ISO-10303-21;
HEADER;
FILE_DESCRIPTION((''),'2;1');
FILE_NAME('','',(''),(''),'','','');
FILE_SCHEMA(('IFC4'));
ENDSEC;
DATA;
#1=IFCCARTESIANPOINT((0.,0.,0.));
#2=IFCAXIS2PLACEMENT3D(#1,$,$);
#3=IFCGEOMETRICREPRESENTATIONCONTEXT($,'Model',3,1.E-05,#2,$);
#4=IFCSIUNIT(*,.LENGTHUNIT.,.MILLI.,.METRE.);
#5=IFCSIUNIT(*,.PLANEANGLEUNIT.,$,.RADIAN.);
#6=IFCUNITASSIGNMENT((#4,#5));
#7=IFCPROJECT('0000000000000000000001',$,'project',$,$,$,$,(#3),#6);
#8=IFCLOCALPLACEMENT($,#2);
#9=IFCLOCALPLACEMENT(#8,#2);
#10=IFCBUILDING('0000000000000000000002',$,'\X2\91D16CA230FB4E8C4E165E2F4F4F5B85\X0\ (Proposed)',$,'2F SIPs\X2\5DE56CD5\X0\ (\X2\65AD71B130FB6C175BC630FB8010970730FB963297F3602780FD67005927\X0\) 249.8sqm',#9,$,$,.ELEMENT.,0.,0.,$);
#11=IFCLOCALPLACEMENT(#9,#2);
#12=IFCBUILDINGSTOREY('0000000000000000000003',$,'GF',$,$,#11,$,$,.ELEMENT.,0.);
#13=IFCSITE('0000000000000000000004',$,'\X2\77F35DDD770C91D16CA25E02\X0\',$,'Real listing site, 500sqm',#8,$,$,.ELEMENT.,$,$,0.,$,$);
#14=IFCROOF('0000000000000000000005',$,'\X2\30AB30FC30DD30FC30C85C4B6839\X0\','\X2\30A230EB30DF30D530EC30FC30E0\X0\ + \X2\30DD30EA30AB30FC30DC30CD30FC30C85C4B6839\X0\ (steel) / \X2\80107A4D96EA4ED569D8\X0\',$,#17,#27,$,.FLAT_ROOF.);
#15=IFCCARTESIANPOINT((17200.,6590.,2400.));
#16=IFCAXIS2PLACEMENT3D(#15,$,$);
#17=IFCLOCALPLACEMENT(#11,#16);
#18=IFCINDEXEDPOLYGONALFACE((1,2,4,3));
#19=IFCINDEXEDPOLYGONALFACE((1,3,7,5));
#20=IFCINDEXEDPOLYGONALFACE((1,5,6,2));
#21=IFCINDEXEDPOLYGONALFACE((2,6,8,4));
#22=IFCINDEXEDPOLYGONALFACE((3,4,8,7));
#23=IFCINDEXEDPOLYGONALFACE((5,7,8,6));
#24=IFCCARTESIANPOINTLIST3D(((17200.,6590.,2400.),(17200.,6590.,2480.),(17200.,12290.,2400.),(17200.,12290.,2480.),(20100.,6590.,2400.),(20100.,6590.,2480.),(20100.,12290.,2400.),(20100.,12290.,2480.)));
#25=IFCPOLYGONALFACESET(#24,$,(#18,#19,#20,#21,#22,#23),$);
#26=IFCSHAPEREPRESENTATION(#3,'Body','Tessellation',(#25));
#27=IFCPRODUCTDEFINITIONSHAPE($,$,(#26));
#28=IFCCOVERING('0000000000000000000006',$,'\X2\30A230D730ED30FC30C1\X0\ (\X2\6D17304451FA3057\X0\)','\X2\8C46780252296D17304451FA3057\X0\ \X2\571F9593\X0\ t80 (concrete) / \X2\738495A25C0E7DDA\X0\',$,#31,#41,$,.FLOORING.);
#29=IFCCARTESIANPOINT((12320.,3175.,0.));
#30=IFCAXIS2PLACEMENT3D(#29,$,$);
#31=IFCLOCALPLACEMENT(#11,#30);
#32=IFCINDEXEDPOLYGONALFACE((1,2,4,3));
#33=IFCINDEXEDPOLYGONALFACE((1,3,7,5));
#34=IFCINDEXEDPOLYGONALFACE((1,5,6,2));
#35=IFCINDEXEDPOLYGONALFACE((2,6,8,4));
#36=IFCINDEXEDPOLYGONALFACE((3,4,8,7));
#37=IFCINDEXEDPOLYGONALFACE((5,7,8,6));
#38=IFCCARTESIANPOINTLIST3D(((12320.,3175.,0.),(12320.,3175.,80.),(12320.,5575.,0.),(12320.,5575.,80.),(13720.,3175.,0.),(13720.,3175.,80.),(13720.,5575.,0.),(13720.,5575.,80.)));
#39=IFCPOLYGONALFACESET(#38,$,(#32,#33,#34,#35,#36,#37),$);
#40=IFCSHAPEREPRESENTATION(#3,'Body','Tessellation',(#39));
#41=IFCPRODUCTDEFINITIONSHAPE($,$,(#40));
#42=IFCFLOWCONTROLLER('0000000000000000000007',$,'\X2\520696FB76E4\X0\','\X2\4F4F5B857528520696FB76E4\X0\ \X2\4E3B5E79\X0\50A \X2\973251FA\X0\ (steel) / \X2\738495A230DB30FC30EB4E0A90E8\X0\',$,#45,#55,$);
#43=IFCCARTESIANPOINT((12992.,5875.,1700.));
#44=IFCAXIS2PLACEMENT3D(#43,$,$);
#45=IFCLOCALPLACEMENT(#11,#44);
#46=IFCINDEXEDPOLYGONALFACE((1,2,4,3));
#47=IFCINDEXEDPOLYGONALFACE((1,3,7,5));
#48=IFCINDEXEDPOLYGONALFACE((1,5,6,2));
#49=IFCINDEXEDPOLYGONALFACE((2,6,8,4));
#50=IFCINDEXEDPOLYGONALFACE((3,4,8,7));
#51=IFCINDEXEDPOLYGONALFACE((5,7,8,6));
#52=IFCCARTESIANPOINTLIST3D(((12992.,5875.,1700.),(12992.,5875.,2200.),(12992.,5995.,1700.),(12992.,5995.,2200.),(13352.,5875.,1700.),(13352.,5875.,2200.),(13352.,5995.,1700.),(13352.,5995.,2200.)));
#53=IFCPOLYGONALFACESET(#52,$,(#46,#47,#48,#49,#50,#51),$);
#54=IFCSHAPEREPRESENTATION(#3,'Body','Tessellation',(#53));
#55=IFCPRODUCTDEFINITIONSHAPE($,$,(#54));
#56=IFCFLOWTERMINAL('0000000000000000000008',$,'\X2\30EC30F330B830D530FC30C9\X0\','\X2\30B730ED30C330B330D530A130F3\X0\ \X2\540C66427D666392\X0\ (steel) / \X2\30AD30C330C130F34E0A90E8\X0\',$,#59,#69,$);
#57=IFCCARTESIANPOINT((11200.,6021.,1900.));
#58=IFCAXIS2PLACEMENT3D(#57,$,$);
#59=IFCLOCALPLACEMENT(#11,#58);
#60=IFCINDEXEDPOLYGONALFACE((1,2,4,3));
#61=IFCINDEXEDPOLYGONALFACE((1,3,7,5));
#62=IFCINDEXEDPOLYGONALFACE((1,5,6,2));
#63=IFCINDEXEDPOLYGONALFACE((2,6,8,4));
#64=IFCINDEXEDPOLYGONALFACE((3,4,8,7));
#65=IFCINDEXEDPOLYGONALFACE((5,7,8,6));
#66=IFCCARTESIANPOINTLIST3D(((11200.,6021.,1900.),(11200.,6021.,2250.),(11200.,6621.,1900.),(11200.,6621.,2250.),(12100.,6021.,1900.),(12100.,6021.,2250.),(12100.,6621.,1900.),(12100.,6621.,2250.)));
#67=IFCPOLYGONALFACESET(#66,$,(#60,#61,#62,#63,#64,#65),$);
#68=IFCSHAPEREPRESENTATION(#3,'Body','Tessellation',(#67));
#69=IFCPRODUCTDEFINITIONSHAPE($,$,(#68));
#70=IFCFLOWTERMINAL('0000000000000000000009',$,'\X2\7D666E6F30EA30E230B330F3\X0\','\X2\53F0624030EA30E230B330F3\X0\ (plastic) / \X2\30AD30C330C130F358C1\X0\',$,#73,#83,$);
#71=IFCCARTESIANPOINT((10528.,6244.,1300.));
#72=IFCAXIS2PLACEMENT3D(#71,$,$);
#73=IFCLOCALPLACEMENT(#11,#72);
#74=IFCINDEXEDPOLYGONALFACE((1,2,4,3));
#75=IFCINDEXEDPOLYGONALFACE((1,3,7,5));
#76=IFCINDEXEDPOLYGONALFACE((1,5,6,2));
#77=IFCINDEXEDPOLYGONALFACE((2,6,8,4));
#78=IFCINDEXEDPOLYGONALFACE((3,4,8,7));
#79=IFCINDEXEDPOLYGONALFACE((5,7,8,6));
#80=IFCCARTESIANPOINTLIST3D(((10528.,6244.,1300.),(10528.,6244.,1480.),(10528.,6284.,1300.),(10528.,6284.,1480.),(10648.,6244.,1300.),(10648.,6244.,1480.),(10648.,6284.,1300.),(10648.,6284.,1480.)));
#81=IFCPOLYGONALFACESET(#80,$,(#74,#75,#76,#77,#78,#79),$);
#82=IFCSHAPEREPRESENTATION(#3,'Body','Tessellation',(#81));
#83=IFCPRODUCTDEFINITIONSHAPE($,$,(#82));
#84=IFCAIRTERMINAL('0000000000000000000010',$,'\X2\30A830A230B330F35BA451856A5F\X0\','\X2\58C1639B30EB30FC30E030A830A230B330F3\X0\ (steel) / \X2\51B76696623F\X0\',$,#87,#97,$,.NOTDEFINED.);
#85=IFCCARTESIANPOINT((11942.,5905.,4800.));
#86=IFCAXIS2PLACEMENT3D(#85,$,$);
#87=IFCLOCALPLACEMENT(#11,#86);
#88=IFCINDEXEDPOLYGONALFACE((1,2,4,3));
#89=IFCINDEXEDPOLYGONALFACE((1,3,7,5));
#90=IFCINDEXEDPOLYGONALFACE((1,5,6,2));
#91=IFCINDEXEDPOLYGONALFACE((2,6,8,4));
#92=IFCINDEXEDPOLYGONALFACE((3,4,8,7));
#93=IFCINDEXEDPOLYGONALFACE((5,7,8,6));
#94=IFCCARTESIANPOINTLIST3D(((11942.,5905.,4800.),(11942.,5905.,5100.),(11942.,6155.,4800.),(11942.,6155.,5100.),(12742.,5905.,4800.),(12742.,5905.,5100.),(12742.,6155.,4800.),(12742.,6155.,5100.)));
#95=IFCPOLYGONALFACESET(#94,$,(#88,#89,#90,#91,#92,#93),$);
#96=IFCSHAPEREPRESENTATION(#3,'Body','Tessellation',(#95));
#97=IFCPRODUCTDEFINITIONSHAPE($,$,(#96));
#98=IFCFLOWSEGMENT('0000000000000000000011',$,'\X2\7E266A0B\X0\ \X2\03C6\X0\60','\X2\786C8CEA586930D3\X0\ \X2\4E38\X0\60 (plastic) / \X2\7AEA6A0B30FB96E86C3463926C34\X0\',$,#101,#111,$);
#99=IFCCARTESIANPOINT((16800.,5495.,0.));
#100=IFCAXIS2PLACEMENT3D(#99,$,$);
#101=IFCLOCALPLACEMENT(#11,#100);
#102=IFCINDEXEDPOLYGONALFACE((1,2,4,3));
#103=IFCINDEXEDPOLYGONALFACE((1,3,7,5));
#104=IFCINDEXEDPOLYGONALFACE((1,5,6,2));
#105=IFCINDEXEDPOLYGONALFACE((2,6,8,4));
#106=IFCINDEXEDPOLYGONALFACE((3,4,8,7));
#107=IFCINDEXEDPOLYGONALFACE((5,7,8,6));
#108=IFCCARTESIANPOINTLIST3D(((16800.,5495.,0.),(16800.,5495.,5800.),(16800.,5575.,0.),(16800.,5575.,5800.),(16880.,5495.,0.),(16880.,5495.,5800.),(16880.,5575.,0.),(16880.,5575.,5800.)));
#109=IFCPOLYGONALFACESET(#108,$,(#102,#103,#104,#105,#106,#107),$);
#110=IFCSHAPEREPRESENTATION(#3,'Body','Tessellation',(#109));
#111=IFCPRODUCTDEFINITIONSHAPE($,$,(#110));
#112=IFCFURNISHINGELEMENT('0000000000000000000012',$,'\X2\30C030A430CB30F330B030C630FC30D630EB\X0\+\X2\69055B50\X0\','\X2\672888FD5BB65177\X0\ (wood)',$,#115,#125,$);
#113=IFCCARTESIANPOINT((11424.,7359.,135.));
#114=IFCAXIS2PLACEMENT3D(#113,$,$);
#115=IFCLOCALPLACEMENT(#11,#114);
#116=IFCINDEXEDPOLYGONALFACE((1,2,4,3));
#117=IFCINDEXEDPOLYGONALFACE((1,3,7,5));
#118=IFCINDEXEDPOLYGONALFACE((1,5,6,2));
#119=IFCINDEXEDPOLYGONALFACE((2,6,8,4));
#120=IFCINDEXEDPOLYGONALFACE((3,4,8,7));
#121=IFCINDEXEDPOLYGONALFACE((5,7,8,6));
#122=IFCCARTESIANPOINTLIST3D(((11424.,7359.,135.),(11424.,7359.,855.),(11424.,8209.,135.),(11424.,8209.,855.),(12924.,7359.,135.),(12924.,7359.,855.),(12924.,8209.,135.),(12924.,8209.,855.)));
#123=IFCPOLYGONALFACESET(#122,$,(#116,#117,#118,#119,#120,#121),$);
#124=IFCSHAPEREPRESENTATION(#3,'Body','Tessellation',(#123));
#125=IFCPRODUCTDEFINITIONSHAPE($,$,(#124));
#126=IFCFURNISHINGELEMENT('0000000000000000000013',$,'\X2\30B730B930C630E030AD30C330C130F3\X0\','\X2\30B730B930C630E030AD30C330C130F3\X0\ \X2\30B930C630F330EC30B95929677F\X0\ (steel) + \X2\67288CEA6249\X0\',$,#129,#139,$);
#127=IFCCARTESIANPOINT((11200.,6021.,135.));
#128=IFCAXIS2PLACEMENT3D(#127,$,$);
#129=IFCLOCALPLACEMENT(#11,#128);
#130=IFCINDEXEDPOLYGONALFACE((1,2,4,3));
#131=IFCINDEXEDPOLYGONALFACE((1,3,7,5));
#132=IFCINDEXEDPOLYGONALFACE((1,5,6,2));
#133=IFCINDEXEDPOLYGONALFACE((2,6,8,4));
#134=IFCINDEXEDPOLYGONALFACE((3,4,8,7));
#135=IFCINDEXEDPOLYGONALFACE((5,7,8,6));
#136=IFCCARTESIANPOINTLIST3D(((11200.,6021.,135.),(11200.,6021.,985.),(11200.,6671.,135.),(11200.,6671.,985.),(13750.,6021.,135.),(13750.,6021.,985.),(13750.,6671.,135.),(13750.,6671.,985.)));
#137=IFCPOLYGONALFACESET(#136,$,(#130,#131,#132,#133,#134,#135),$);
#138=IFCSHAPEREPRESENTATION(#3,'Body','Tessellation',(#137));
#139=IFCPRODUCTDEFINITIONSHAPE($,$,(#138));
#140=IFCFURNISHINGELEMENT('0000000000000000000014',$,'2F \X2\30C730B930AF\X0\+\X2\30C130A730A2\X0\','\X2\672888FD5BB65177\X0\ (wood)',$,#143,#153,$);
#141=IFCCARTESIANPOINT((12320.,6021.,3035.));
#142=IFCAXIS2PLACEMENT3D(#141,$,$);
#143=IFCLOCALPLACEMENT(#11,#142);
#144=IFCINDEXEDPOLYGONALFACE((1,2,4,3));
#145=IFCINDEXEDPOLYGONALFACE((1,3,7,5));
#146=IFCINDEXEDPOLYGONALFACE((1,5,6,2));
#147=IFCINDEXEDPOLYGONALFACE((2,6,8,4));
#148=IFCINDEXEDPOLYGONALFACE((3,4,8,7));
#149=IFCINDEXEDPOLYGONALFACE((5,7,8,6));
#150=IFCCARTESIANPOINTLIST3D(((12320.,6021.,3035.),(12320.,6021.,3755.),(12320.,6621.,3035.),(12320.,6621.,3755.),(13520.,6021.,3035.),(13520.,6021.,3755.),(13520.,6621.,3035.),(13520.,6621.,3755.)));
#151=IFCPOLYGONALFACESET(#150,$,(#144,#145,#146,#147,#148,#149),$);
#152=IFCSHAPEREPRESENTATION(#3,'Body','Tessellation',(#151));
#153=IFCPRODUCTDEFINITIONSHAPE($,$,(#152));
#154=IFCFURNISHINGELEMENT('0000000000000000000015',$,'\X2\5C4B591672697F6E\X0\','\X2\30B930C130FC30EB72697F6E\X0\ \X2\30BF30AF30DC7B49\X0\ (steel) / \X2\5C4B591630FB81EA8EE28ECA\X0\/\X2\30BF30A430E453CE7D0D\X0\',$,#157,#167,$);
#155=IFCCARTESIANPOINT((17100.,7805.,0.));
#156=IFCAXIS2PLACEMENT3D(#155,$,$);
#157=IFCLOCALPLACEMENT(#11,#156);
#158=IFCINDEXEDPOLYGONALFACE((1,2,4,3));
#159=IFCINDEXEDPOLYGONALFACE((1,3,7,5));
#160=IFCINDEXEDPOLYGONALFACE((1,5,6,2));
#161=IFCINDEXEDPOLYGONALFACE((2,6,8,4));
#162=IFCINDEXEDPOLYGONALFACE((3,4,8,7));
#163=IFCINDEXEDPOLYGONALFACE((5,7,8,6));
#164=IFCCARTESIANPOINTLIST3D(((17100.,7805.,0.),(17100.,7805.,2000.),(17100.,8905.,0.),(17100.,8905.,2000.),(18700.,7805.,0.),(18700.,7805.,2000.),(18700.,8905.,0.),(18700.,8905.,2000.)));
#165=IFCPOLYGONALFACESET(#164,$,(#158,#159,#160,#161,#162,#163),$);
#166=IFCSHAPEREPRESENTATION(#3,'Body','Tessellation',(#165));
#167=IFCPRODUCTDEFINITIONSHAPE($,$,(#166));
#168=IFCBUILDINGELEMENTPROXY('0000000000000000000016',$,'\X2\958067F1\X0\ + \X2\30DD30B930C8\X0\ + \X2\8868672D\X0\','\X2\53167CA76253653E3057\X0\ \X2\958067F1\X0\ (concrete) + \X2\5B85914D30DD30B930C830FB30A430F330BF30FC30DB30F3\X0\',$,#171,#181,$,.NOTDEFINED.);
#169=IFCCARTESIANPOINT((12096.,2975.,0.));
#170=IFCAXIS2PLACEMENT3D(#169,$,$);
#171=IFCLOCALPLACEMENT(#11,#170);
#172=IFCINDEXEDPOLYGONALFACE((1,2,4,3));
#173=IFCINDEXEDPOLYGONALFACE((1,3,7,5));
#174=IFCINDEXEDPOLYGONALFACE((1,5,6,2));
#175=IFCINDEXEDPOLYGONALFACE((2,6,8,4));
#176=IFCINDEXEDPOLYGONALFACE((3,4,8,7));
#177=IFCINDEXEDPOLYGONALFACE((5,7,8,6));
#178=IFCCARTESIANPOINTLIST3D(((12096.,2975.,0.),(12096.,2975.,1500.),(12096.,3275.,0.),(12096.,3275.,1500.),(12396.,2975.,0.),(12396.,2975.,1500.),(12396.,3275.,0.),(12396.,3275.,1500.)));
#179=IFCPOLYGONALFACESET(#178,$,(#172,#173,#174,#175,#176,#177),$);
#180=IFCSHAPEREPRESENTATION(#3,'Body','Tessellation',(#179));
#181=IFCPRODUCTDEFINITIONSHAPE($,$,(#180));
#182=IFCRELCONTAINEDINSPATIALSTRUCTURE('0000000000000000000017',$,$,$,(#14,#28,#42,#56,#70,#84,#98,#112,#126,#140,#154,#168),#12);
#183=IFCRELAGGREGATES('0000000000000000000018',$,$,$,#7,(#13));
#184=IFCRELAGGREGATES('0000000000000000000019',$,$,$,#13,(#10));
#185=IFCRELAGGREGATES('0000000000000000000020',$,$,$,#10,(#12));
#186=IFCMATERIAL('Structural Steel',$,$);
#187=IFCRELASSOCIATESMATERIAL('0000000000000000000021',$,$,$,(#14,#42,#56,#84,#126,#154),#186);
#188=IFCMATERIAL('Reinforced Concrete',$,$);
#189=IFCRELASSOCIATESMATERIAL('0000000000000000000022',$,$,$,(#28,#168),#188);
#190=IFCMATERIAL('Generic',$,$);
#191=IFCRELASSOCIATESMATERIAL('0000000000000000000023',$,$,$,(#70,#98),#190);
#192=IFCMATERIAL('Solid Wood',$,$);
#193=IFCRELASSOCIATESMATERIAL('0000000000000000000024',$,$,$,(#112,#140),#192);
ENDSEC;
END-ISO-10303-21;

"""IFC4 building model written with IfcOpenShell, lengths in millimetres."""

from ifc_helpers import new_model, si_unit, frame, frame_2d, origin, place, context, project, spatial, rectangle, extrude, material, element, save


model = new_model("IFC4")

# Units and contexts
model_context = context("Model", 3, precision=1e-05, world=origin())
ifc_project = project(units=[si_unit("LENGTHUNIT", "METRE", prefix="MILLI"), si_unit("PLANEANGLEUNIT", "RADIAN")], contexts=[model_context])

# Site, building, storey
site_placement = place(None, origin())
site = spatial("IfcSite", under=ifc_project, at=site_placement, Name="石川県金沢市", ObjectType="Real listing site, 500sqm", CompositionType="ELEMENT", RefElevation=0.0)
building_placement = place(site_placement, origin())
building = spatial("IfcBuilding", under=site, at=building_placement, Name="金沢・二世帯住宅 (Proposed)", ObjectType="2F SIPs工法 (断熱・気密・耐震・防音性能最大) 249.8sqm", CompositionType="ELEMENT", ElevationOfRefHeight=0.0, ElevationOfTerrain=0.0)
storey_placement = place(building_placement, origin())
storey = spatial("IfcBuildingStorey", under=building, at=storey_placement, Name="GF", CompositionType="ELEMENT", Elevation=0.0)

# Shared definitions
ifc_material_1 = material(Name="Solid Wood")
ifc_material_2 = material(Name="Structural Steel")

# Shared definitions
ifc_material_3 = material(Name="Reinforced Concrete")

# Roof
roof_placement = place(storey_placement, frame((17200.0, 6590.0, 2400.0)))
element("IfcRoof", 1, at=roof_placement, inside=storey, material=ifc_material_2, Name="カーポート屋根", Description="アルミフレーム + ポリカーボネート屋根 (steel) / 耐積雪仕様", PredefinedType="FLAT_ROOF", context=model_context, shape_type="SweptSolid", body=[
    extrude(rectangle(XDim=2900.0, YDim=5700.0, at=frame_2d((1450.0, 2850.0))), frame((17200.0, 6590.0, 2400.0)), (0.0, 0.0, 1.0), 80.0),
])

# Covering
covering_placement = place(storey_placement, frame((12320.0, 3175.0, 0.0)))
element("IfcCovering", 2, at=covering_placement, inside=storey, material=ifc_material_3, Name="アプローチ (洗い出し)", Description="豆砂利洗い出し 土間 t80 (concrete) / 玄関導線", PredefinedType="FLOORING", context=model_context, shape_type="SweptSolid", body=[
    extrude(rectangle(XDim=1400.0, YDim=2400.0, at=frame_2d((700.0, 1200.0))), frame((12320.0, 3175.0, 0.0)), (0.0, 0.0, 1.0), 80.0),
])

# Flow controller
flow_controller_placement = place(storey_placement, frame((12992.0, 5875.0, 1700.0)))
element("IfcFlowController", 3, at=flow_controller_placement, inside=storey, material=ifc_material_2, Name="分電盤", Description="住宅用分電盤 主幹50A 露出 (steel) / 玄関ホール上部", context=model_context, shape_type="SweptSolid", body=[
    extrude(rectangle(XDim=360.0, YDim=120.0, at=frame_2d((180.0, 60.0))), frame((12992.0, 5875.0, 1700.0)), (0.0, 0.0, 1.0), 500.0),
])

# Flow terminals
flow_terminal_1_placement = place(storey_placement, frame((11200.0, 6021.0, 1900.0)))
element("IfcFlowTerminal", 4, at=flow_terminal_1_placement, inside=storey, material=ifc_material_2, Name="レンジフード", Description="シロッコファン 同時給排 (steel) / キッチン上部", context=model_context, shape_type="SweptSolid", body=[
    extrude(rectangle(XDim=900.0, YDim=600.0, at=frame_2d((450.0, 300.0))), frame((11200.0, 6021.0, 1900.0)), (0.0, 0.0, 1.0), 350.0),
])
ifc_material_4 = material(Name="Generic")
flow_terminal_2_placement = place(storey_placement, frame((10528.0, 6244.0, 1300.0)))
element("IfcFlowTerminal", 5, at=flow_terminal_2_placement, inside=storey, material=ifc_material_4, Name="給湯リモコン", Description="台所リモコン (plastic) / キッチン壁", context=model_context, shape_type="SweptSolid", body=[
    extrude(rectangle(XDim=120.0, YDim=40.0, at=frame_2d((60.0, 20.0))), frame((10528.0, 6244.0, 1300.0)), (0.0, 0.0, 1.0), 180.0),
])

# Air terminal
air_terminal_placement = place(storey_placement, frame((11942.0, 5905.0, 4800.0)))
element("IfcAirTerminal", 6, at=air_terminal_placement, inside=storey, material=ifc_material_2, Name="エアコン室内機", Description="壁掛ルームエアコン (steel) / 冷暖房", PredefinedType="NOTDEFINED", context=model_context, shape_type="SweptSolid", body=[
    extrude(rectangle(XDim=800.0, YDim=250.0, at=frame_2d((400.0, 125.0))), frame((11942.0, 5905.0, 4800.0)), (0.0, 0.0, 1.0), 300.0),
])

# Flow segment
flow_segment_placement = place(storey_placement, frame((16800.0, 5495.0, 0.0)))
element("IfcFlowSegment", 7, at=flow_segment_placement, inside=storey, material=ifc_material_4, Name="縦樋 φ60", Description="硬質塩ビ 丸60 (plastic) / 竪樋・雨水排水", context=model_context, shape_type="SweptSolid", body=[
    extrude(rectangle(XDim=80.0, YDim=80.0, at=frame_2d((40.0, 40.0))), frame((16800.0, 5495.0, 0.0)), (0.0, 0.0, 1.0), 5800.0),
])

# Furnishing elements
furnishing_1_placement = place(storey_placement, frame((11424.0, 7359.0, 135.0)))
element("IfcFurnishingElement", 8, at=furnishing_1_placement, inside=storey, material=ifc_material_1, Name="ダイニングテーブル+椅子", Description="木製家具 (wood)", context=model_context, shape_type="SweptSolid", body=[
    extrude(rectangle(XDim=1500.0, YDim=850.0, at=frame_2d((750.0, 425.0))), frame((11424.0, 7359.0, 135.0)), (0.0, 0.0, 1.0), 720.0),
])
furnishing_2_placement = place(storey_placement, frame((11200.0, 6021.0, 135.0)))
element("IfcFurnishingElement", 9, at=furnishing_2_placement, inside=storey, material=ifc_material_2, Name="システムキッチン", Description="システムキッチン ステンレス天板 (steel) + 木質扉", context=model_context, shape_type="SweptSolid", body=[
    extrude(rectangle(XDim=2550.0, YDim=650.0, at=frame_2d((1275.0, 325.0))), frame((11200.0, 6021.0, 135.0)), (0.0, 0.0, 1.0), 850.0),
])
furnishing_3_placement = place(storey_placement, frame((12320.0, 6021.0, 3035.0)))
element("IfcFurnishingElement", 10, at=furnishing_3_placement, inside=storey, material=ifc_material_1, Name="2F デスク+チェア", Description="木製家具 (wood)", context=model_context, shape_type="SweptSolid", body=[
    extrude(rectangle(XDim=1200.0, YDim=600.0, at=frame_2d((600.0, 300.0))), frame((12320.0, 6021.0, 3035.0)), (0.0, 0.0, 1.0), 720.0),
])
furnishing_4_placement = place(storey_placement, frame((17100.0, 7805.0, 0.0)))
element("IfcFurnishingElement", 11, at=furnishing_4_placement, inside=storey, material=ifc_material_2, Name="屋外物置", Description="スチール物置 タクボ等 (steel) / 屋外・自転車/タイヤ収納", context=model_context, shape_type="SweptSolid", body=[
    extrude(rectangle(XDim=1600.0, YDim=1100.0, at=frame_2d((800.0, 550.0))), frame((17100.0, 7805.0, 0.0)), (0.0, 0.0, 1.0), 2000.0),
])

# Building element proxy
proxy_placement = place(storey_placement, frame((12096.0, 2975.0, 0.0)))
element("IfcBuildingElementProxy", 12, at=proxy_placement, inside=storey, material=ifc_material_3, Name="門柱 + ポスト + 表札", Description="化粧打放し 門柱 (concrete) + 宅配ポスト・インターホン", PredefinedType="NOTDEFINED", context=model_context, shape_type="SweptSolid", body=[
    extrude(rectangle(XDim=300.0, YDim=300.0, at=frame_2d((150.0, 150.0))), frame((12096.0, 2975.0, 0.0)), (0.0, 0.0, 1.0), 1500.0),
])

save(model, "model.ifc")
